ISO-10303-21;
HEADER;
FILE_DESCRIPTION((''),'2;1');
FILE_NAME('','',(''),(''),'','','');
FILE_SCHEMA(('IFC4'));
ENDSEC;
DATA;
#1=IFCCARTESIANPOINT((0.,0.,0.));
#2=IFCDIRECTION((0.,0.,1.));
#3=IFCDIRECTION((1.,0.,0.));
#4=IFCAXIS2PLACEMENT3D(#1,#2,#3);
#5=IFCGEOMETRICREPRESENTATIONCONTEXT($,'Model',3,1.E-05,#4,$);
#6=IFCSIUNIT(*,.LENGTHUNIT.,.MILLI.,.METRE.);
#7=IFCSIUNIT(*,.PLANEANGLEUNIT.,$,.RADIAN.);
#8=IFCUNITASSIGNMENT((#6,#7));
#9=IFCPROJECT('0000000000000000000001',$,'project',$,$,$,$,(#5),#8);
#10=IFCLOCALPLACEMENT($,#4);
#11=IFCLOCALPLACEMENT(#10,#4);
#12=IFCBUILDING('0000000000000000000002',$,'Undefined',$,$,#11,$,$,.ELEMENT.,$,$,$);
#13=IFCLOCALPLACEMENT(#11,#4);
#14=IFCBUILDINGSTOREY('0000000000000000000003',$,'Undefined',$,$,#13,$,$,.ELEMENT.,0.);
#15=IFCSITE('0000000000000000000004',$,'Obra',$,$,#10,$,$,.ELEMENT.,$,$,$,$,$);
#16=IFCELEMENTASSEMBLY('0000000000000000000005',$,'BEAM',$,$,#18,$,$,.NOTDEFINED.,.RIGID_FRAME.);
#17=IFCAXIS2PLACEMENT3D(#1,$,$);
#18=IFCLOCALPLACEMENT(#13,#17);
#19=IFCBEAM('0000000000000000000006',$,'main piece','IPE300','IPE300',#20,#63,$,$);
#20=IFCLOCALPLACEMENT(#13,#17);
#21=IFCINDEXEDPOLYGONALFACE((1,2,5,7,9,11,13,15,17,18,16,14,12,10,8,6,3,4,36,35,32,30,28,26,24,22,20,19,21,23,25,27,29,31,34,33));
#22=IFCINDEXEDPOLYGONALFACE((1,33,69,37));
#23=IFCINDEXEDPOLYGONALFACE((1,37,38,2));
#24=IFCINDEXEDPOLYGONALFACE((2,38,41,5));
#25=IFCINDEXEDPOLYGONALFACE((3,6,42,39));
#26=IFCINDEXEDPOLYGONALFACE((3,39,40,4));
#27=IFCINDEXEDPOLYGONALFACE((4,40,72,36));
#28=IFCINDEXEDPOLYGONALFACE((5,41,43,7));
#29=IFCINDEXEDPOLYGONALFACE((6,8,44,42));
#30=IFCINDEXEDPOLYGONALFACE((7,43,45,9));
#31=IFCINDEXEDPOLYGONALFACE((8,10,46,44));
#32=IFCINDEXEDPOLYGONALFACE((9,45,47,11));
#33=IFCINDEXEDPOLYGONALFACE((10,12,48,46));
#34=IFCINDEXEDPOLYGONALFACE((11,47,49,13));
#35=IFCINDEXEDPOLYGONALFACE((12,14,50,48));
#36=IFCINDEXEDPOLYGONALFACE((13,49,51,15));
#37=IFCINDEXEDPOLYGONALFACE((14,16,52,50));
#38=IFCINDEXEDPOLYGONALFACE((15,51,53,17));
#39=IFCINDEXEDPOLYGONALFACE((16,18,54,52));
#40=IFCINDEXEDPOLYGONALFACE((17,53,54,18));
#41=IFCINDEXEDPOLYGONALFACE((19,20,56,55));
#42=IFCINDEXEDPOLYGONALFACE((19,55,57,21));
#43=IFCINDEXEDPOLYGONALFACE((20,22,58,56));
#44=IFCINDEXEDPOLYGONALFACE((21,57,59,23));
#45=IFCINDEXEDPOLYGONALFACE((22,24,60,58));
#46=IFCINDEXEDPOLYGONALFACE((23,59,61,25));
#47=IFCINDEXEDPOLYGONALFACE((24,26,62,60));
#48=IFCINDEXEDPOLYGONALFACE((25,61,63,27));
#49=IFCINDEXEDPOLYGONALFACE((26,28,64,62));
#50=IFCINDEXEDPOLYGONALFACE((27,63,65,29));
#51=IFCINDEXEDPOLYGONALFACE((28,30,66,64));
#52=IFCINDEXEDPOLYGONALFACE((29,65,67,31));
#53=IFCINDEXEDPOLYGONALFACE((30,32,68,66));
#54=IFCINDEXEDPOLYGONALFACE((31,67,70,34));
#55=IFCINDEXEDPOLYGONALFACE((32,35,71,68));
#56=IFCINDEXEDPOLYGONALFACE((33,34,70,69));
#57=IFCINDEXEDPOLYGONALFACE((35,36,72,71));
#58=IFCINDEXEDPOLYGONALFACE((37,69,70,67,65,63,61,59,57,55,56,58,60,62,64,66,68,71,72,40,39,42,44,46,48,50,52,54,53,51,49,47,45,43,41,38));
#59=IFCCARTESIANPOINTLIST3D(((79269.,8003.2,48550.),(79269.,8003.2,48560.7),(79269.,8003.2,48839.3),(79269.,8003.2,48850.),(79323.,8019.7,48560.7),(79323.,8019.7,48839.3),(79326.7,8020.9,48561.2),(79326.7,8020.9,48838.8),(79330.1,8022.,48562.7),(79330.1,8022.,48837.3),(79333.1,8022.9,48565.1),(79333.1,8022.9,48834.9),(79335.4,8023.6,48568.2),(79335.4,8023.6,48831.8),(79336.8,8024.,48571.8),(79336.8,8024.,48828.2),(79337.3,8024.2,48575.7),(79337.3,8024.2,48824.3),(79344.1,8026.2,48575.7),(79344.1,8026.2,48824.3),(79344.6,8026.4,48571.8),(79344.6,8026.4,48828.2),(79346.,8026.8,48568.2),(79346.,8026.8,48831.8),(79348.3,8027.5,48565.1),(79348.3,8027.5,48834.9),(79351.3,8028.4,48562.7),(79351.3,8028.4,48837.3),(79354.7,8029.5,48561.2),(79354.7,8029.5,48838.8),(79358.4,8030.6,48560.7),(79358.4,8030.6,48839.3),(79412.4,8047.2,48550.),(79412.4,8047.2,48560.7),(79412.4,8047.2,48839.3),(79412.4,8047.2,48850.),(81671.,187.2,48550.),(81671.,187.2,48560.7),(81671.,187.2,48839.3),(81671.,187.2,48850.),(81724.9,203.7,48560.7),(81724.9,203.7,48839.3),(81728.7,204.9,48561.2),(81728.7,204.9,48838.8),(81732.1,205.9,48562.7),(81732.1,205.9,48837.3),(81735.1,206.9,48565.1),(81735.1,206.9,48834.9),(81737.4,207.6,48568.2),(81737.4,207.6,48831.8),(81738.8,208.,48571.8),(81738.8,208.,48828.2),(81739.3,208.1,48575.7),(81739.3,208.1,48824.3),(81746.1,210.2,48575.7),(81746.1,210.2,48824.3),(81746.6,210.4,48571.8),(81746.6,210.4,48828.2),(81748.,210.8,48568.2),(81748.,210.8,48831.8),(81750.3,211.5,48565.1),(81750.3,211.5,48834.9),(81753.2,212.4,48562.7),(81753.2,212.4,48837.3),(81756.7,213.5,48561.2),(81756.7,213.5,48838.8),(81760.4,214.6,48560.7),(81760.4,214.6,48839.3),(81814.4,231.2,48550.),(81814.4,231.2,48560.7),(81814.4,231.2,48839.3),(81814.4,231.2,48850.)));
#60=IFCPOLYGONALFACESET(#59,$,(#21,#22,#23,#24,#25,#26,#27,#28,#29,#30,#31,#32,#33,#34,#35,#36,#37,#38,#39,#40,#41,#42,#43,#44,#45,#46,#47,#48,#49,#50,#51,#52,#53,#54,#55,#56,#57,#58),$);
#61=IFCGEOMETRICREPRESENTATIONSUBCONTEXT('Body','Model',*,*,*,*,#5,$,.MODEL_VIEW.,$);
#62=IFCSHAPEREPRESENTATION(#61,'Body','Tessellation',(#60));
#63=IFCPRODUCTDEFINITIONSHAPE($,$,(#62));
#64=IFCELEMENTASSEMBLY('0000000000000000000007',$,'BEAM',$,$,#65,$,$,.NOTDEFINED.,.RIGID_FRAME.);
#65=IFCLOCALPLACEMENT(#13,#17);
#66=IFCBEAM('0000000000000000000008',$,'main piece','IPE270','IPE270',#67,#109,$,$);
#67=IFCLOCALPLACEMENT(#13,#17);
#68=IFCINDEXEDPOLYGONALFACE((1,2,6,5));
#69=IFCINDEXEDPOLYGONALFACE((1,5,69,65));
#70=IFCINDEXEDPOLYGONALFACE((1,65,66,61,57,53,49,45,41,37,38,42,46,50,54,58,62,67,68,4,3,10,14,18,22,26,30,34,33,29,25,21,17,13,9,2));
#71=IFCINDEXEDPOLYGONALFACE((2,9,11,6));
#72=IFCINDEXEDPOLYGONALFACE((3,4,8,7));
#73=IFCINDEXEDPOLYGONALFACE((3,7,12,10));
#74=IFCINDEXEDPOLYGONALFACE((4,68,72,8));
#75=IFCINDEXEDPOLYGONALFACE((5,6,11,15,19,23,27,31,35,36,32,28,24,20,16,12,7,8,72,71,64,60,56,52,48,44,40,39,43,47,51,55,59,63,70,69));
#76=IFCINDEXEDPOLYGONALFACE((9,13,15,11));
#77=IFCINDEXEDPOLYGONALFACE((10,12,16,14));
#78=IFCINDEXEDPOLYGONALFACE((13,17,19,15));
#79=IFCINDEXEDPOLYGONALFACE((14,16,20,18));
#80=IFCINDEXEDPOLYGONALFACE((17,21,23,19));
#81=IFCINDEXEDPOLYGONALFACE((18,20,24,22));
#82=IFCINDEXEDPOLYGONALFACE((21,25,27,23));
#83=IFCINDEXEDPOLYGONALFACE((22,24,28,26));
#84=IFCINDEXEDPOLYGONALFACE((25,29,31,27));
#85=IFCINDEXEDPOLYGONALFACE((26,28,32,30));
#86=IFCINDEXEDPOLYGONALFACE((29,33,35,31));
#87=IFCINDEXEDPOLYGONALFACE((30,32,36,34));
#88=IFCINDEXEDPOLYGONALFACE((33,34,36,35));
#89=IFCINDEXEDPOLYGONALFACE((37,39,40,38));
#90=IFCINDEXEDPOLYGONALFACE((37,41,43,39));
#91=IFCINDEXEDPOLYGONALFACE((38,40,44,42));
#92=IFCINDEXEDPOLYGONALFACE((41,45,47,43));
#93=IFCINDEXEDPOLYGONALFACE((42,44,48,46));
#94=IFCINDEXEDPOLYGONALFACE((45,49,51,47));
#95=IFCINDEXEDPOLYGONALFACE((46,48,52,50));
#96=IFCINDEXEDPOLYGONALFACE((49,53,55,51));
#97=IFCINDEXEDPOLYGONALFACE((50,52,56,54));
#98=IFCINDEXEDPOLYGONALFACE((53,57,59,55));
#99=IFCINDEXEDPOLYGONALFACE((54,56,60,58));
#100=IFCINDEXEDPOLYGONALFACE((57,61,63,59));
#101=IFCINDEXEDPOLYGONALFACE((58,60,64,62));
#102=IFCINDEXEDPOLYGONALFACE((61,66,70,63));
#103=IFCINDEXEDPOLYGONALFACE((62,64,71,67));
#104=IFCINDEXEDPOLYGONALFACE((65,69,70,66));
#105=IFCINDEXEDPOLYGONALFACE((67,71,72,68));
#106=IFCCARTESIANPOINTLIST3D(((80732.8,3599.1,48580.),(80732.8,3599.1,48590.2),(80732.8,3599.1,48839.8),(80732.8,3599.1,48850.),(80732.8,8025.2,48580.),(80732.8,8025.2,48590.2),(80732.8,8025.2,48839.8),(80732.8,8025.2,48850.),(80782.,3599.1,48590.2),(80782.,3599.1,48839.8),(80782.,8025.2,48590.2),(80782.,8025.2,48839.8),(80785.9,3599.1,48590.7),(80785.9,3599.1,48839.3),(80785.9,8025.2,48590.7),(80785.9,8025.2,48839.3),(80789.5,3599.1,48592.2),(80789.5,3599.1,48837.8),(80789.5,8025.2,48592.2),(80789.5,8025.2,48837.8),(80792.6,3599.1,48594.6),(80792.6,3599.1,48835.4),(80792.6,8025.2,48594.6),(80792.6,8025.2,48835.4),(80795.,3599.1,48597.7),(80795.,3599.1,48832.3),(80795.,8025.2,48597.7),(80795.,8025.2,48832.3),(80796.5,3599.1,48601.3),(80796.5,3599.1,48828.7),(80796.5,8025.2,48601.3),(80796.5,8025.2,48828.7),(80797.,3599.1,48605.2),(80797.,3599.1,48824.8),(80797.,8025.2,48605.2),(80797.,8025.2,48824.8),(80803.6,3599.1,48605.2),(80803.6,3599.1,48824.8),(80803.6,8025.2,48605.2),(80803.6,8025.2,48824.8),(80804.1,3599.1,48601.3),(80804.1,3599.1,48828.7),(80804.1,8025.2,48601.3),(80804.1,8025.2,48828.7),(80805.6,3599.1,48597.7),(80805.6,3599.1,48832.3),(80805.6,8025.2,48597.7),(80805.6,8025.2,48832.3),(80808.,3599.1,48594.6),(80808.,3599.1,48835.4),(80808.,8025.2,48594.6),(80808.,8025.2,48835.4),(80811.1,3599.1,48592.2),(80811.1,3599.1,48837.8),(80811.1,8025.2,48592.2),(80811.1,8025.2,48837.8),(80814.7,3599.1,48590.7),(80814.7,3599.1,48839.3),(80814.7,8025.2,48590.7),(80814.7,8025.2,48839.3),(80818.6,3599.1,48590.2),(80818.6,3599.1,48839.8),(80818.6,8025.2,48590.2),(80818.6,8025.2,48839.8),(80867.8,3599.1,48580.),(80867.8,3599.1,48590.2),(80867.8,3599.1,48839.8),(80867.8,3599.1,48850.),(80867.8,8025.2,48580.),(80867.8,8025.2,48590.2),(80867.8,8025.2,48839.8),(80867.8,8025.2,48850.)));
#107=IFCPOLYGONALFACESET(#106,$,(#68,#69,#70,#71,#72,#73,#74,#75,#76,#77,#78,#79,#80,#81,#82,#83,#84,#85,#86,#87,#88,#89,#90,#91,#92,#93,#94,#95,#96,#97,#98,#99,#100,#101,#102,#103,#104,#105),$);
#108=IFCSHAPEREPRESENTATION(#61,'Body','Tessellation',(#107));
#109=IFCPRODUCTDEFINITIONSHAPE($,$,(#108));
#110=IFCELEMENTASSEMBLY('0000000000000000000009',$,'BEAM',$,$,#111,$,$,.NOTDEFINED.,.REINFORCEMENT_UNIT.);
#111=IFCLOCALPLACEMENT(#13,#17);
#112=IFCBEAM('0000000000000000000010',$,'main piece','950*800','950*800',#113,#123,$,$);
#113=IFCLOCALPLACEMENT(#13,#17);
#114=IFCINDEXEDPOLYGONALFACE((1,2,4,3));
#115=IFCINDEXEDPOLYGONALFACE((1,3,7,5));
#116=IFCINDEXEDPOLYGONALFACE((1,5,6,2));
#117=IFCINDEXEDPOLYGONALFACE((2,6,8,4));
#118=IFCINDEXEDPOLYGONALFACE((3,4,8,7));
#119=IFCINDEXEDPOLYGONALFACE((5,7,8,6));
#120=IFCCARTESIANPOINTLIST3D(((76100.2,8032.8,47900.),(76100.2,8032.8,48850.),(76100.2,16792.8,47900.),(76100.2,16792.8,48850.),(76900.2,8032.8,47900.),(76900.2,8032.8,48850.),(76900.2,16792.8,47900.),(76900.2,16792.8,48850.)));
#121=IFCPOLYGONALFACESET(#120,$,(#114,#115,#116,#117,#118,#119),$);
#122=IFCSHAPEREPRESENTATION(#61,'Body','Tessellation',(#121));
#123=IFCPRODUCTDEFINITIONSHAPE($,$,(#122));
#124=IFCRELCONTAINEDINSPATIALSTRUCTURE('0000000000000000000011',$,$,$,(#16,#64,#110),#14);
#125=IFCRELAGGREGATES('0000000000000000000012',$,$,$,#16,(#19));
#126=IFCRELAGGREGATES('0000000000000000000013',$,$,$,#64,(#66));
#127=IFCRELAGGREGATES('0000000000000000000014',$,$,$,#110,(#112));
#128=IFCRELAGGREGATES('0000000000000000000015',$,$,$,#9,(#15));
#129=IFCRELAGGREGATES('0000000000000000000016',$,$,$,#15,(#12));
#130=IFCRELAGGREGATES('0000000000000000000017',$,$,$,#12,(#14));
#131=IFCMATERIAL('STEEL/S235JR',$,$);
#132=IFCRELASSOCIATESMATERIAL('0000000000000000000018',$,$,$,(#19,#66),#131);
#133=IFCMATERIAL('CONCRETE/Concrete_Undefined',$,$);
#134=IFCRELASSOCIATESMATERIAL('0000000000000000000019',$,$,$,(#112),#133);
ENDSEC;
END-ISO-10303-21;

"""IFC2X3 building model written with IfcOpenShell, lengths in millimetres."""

from ifc_helpers import new_model, si_unit, frame, origin_with_axes, origin_2d_with_axis, place, context, subcontext, project, spatial, rectangle, i_section, extrude, material, element, aggregate, save


model = new_model("IFC2X3")

# Units and contexts
model_context = context("Model", 3, precision=1e-05, world=origin_with_axes())
body_context = subcontext(model_context, "Body", "Model", "MODEL_VIEW")
ifc_project = project(units=[si_unit("LENGTHUNIT", "METRE", prefix="MILLI"), si_unit("PLANEANGLEUNIT", "RADIAN")], contexts=[model_context])

# Site, building, storey
site_placement = place(None, origin_with_axes())
site = spatial("IfcSite", under=ifc_project, at=site_placement, Name="Obra", CompositionType="ELEMENT")
building_placement = place(site_placement, origin_with_axes())
building = spatial("IfcBuilding", under=site, at=building_placement, Name="Undefined", CompositionType="ELEMENT")
storey_placement = place(building_placement, origin_with_axes())
storey = spatial("IfcBuildingStorey", under=building, at=storey_placement, Name="Undefined", CompositionType="ELEMENT", Elevation=0.0)

# Shared definitions
ifc_material_1 = material(Name="STEEL/S235JR")

# Shared definitions
ifc_material_2 = material(Name="CONCRETE/Concrete_Undefined")

# Element assemblies, beams
assembly_1_placement = place(storey_placement, origin_with_axes())
assembly_1 = element("IfcElementAssembly", 1, at=assembly_1_placement, inside=storey, Name="BEAM", AssemblyPlace="NOTDEFINED", PredefinedType="RIGID_FRAME")
beam_1_placement = place(assembly_1_placement, frame((79340.7, 8025.2, 48700.0), z_axis=(0.0, 0.0, 1.0), x_axis=(0.293756, -0.955881, 0.0)))
beam_1 = element("IfcBeam", 2, at=beam_1_placement, material=ifc_material_1, Name="main piece", Description="IPE300", ObjectType="IPE300", context=body_context, shape_type="SweptSolid", body=[
    extrude(i_section(OverallWidth=150.0, OverallDepth=300.0, WebThickness=7.1, FlangeThickness=10.7, FilletRadius=15.0, at=origin_2d_with_axis()), frame((8176.8, 0.0, 0.0), z_axis=(-1.0, 0.0, 0.0), x_axis=(0.0, -1.0, 0.0)), (0.0, 0.0, 1.0), 8176.8),
])
aggregate(assembly_1, [beam_1])
assembly_2_placement = place(storey_placement, origin_with_axes())
assembly_2 = element("IfcElementAssembly", 3, at=assembly_2_placement, inside=storey, Name="BEAM", AssemblyPlace="NOTDEFINED", PredefinedType="RIGID_FRAME")
beam_2_placement = place(assembly_2_placement, frame((80800.3, 3599.1, 48715.0), z_axis=(0.0, 0.0, 1.0), x_axis=(0.0, 1.0, 0.0)))
beam_2 = element("IfcBeam", 4, at=beam_2_placement, material=ifc_material_1, Name="main piece", Description="IPE270", ObjectType="IPE270", context=body_context, shape_type="SweptSolid", body=[
    extrude(i_section(OverallWidth=135.0, OverallDepth=270.0, WebThickness=6.6, FlangeThickness=10.2, FilletRadius=15.0, at=origin_2d_with_axis()), frame((4426.1, 0.0, 0.0), z_axis=(-1.0, 0.0, 0.0), x_axis=(0.0, -1.0, 0.0)), (0.0, 0.0, 1.0), 4426.1),
])
aggregate(assembly_2, [beam_2])
assembly_3_placement = place(storey_placement, origin_with_axes())
assembly_3 = element("IfcElementAssembly", 5, at=assembly_3_placement, inside=storey, Name="BEAM", AssemblyPlace="NOTDEFINED", PredefinedType="REINFORCEMENT_UNIT")
beam_3_placement = place(assembly_3_placement, frame((76500.2, 8032.8, 48375.0), z_axis=(0.0, 0.0, 1.0), x_axis=(0.0, 1.0, 0.0)))
beam_3 = element("IfcBeam", 6, at=beam_3_placement, material=ifc_material_2, Name="main piece", Description="950*800", ObjectType="950*800", context=body_context, shape_type="SweptSolid", body=[
    extrude(rectangle(XDim=800.0, YDim=950.0, at=origin_2d_with_axis()), frame((8760.0, 0.0, 0.0), z_axis=(-1.0, 0.0, 0.0), x_axis=(0.0, -1.0, 0.0)), (0.0, 0.0, 1.0), 8760.0),
])
aggregate(assembly_3, [beam_3])

save(model, "model.ifc")
